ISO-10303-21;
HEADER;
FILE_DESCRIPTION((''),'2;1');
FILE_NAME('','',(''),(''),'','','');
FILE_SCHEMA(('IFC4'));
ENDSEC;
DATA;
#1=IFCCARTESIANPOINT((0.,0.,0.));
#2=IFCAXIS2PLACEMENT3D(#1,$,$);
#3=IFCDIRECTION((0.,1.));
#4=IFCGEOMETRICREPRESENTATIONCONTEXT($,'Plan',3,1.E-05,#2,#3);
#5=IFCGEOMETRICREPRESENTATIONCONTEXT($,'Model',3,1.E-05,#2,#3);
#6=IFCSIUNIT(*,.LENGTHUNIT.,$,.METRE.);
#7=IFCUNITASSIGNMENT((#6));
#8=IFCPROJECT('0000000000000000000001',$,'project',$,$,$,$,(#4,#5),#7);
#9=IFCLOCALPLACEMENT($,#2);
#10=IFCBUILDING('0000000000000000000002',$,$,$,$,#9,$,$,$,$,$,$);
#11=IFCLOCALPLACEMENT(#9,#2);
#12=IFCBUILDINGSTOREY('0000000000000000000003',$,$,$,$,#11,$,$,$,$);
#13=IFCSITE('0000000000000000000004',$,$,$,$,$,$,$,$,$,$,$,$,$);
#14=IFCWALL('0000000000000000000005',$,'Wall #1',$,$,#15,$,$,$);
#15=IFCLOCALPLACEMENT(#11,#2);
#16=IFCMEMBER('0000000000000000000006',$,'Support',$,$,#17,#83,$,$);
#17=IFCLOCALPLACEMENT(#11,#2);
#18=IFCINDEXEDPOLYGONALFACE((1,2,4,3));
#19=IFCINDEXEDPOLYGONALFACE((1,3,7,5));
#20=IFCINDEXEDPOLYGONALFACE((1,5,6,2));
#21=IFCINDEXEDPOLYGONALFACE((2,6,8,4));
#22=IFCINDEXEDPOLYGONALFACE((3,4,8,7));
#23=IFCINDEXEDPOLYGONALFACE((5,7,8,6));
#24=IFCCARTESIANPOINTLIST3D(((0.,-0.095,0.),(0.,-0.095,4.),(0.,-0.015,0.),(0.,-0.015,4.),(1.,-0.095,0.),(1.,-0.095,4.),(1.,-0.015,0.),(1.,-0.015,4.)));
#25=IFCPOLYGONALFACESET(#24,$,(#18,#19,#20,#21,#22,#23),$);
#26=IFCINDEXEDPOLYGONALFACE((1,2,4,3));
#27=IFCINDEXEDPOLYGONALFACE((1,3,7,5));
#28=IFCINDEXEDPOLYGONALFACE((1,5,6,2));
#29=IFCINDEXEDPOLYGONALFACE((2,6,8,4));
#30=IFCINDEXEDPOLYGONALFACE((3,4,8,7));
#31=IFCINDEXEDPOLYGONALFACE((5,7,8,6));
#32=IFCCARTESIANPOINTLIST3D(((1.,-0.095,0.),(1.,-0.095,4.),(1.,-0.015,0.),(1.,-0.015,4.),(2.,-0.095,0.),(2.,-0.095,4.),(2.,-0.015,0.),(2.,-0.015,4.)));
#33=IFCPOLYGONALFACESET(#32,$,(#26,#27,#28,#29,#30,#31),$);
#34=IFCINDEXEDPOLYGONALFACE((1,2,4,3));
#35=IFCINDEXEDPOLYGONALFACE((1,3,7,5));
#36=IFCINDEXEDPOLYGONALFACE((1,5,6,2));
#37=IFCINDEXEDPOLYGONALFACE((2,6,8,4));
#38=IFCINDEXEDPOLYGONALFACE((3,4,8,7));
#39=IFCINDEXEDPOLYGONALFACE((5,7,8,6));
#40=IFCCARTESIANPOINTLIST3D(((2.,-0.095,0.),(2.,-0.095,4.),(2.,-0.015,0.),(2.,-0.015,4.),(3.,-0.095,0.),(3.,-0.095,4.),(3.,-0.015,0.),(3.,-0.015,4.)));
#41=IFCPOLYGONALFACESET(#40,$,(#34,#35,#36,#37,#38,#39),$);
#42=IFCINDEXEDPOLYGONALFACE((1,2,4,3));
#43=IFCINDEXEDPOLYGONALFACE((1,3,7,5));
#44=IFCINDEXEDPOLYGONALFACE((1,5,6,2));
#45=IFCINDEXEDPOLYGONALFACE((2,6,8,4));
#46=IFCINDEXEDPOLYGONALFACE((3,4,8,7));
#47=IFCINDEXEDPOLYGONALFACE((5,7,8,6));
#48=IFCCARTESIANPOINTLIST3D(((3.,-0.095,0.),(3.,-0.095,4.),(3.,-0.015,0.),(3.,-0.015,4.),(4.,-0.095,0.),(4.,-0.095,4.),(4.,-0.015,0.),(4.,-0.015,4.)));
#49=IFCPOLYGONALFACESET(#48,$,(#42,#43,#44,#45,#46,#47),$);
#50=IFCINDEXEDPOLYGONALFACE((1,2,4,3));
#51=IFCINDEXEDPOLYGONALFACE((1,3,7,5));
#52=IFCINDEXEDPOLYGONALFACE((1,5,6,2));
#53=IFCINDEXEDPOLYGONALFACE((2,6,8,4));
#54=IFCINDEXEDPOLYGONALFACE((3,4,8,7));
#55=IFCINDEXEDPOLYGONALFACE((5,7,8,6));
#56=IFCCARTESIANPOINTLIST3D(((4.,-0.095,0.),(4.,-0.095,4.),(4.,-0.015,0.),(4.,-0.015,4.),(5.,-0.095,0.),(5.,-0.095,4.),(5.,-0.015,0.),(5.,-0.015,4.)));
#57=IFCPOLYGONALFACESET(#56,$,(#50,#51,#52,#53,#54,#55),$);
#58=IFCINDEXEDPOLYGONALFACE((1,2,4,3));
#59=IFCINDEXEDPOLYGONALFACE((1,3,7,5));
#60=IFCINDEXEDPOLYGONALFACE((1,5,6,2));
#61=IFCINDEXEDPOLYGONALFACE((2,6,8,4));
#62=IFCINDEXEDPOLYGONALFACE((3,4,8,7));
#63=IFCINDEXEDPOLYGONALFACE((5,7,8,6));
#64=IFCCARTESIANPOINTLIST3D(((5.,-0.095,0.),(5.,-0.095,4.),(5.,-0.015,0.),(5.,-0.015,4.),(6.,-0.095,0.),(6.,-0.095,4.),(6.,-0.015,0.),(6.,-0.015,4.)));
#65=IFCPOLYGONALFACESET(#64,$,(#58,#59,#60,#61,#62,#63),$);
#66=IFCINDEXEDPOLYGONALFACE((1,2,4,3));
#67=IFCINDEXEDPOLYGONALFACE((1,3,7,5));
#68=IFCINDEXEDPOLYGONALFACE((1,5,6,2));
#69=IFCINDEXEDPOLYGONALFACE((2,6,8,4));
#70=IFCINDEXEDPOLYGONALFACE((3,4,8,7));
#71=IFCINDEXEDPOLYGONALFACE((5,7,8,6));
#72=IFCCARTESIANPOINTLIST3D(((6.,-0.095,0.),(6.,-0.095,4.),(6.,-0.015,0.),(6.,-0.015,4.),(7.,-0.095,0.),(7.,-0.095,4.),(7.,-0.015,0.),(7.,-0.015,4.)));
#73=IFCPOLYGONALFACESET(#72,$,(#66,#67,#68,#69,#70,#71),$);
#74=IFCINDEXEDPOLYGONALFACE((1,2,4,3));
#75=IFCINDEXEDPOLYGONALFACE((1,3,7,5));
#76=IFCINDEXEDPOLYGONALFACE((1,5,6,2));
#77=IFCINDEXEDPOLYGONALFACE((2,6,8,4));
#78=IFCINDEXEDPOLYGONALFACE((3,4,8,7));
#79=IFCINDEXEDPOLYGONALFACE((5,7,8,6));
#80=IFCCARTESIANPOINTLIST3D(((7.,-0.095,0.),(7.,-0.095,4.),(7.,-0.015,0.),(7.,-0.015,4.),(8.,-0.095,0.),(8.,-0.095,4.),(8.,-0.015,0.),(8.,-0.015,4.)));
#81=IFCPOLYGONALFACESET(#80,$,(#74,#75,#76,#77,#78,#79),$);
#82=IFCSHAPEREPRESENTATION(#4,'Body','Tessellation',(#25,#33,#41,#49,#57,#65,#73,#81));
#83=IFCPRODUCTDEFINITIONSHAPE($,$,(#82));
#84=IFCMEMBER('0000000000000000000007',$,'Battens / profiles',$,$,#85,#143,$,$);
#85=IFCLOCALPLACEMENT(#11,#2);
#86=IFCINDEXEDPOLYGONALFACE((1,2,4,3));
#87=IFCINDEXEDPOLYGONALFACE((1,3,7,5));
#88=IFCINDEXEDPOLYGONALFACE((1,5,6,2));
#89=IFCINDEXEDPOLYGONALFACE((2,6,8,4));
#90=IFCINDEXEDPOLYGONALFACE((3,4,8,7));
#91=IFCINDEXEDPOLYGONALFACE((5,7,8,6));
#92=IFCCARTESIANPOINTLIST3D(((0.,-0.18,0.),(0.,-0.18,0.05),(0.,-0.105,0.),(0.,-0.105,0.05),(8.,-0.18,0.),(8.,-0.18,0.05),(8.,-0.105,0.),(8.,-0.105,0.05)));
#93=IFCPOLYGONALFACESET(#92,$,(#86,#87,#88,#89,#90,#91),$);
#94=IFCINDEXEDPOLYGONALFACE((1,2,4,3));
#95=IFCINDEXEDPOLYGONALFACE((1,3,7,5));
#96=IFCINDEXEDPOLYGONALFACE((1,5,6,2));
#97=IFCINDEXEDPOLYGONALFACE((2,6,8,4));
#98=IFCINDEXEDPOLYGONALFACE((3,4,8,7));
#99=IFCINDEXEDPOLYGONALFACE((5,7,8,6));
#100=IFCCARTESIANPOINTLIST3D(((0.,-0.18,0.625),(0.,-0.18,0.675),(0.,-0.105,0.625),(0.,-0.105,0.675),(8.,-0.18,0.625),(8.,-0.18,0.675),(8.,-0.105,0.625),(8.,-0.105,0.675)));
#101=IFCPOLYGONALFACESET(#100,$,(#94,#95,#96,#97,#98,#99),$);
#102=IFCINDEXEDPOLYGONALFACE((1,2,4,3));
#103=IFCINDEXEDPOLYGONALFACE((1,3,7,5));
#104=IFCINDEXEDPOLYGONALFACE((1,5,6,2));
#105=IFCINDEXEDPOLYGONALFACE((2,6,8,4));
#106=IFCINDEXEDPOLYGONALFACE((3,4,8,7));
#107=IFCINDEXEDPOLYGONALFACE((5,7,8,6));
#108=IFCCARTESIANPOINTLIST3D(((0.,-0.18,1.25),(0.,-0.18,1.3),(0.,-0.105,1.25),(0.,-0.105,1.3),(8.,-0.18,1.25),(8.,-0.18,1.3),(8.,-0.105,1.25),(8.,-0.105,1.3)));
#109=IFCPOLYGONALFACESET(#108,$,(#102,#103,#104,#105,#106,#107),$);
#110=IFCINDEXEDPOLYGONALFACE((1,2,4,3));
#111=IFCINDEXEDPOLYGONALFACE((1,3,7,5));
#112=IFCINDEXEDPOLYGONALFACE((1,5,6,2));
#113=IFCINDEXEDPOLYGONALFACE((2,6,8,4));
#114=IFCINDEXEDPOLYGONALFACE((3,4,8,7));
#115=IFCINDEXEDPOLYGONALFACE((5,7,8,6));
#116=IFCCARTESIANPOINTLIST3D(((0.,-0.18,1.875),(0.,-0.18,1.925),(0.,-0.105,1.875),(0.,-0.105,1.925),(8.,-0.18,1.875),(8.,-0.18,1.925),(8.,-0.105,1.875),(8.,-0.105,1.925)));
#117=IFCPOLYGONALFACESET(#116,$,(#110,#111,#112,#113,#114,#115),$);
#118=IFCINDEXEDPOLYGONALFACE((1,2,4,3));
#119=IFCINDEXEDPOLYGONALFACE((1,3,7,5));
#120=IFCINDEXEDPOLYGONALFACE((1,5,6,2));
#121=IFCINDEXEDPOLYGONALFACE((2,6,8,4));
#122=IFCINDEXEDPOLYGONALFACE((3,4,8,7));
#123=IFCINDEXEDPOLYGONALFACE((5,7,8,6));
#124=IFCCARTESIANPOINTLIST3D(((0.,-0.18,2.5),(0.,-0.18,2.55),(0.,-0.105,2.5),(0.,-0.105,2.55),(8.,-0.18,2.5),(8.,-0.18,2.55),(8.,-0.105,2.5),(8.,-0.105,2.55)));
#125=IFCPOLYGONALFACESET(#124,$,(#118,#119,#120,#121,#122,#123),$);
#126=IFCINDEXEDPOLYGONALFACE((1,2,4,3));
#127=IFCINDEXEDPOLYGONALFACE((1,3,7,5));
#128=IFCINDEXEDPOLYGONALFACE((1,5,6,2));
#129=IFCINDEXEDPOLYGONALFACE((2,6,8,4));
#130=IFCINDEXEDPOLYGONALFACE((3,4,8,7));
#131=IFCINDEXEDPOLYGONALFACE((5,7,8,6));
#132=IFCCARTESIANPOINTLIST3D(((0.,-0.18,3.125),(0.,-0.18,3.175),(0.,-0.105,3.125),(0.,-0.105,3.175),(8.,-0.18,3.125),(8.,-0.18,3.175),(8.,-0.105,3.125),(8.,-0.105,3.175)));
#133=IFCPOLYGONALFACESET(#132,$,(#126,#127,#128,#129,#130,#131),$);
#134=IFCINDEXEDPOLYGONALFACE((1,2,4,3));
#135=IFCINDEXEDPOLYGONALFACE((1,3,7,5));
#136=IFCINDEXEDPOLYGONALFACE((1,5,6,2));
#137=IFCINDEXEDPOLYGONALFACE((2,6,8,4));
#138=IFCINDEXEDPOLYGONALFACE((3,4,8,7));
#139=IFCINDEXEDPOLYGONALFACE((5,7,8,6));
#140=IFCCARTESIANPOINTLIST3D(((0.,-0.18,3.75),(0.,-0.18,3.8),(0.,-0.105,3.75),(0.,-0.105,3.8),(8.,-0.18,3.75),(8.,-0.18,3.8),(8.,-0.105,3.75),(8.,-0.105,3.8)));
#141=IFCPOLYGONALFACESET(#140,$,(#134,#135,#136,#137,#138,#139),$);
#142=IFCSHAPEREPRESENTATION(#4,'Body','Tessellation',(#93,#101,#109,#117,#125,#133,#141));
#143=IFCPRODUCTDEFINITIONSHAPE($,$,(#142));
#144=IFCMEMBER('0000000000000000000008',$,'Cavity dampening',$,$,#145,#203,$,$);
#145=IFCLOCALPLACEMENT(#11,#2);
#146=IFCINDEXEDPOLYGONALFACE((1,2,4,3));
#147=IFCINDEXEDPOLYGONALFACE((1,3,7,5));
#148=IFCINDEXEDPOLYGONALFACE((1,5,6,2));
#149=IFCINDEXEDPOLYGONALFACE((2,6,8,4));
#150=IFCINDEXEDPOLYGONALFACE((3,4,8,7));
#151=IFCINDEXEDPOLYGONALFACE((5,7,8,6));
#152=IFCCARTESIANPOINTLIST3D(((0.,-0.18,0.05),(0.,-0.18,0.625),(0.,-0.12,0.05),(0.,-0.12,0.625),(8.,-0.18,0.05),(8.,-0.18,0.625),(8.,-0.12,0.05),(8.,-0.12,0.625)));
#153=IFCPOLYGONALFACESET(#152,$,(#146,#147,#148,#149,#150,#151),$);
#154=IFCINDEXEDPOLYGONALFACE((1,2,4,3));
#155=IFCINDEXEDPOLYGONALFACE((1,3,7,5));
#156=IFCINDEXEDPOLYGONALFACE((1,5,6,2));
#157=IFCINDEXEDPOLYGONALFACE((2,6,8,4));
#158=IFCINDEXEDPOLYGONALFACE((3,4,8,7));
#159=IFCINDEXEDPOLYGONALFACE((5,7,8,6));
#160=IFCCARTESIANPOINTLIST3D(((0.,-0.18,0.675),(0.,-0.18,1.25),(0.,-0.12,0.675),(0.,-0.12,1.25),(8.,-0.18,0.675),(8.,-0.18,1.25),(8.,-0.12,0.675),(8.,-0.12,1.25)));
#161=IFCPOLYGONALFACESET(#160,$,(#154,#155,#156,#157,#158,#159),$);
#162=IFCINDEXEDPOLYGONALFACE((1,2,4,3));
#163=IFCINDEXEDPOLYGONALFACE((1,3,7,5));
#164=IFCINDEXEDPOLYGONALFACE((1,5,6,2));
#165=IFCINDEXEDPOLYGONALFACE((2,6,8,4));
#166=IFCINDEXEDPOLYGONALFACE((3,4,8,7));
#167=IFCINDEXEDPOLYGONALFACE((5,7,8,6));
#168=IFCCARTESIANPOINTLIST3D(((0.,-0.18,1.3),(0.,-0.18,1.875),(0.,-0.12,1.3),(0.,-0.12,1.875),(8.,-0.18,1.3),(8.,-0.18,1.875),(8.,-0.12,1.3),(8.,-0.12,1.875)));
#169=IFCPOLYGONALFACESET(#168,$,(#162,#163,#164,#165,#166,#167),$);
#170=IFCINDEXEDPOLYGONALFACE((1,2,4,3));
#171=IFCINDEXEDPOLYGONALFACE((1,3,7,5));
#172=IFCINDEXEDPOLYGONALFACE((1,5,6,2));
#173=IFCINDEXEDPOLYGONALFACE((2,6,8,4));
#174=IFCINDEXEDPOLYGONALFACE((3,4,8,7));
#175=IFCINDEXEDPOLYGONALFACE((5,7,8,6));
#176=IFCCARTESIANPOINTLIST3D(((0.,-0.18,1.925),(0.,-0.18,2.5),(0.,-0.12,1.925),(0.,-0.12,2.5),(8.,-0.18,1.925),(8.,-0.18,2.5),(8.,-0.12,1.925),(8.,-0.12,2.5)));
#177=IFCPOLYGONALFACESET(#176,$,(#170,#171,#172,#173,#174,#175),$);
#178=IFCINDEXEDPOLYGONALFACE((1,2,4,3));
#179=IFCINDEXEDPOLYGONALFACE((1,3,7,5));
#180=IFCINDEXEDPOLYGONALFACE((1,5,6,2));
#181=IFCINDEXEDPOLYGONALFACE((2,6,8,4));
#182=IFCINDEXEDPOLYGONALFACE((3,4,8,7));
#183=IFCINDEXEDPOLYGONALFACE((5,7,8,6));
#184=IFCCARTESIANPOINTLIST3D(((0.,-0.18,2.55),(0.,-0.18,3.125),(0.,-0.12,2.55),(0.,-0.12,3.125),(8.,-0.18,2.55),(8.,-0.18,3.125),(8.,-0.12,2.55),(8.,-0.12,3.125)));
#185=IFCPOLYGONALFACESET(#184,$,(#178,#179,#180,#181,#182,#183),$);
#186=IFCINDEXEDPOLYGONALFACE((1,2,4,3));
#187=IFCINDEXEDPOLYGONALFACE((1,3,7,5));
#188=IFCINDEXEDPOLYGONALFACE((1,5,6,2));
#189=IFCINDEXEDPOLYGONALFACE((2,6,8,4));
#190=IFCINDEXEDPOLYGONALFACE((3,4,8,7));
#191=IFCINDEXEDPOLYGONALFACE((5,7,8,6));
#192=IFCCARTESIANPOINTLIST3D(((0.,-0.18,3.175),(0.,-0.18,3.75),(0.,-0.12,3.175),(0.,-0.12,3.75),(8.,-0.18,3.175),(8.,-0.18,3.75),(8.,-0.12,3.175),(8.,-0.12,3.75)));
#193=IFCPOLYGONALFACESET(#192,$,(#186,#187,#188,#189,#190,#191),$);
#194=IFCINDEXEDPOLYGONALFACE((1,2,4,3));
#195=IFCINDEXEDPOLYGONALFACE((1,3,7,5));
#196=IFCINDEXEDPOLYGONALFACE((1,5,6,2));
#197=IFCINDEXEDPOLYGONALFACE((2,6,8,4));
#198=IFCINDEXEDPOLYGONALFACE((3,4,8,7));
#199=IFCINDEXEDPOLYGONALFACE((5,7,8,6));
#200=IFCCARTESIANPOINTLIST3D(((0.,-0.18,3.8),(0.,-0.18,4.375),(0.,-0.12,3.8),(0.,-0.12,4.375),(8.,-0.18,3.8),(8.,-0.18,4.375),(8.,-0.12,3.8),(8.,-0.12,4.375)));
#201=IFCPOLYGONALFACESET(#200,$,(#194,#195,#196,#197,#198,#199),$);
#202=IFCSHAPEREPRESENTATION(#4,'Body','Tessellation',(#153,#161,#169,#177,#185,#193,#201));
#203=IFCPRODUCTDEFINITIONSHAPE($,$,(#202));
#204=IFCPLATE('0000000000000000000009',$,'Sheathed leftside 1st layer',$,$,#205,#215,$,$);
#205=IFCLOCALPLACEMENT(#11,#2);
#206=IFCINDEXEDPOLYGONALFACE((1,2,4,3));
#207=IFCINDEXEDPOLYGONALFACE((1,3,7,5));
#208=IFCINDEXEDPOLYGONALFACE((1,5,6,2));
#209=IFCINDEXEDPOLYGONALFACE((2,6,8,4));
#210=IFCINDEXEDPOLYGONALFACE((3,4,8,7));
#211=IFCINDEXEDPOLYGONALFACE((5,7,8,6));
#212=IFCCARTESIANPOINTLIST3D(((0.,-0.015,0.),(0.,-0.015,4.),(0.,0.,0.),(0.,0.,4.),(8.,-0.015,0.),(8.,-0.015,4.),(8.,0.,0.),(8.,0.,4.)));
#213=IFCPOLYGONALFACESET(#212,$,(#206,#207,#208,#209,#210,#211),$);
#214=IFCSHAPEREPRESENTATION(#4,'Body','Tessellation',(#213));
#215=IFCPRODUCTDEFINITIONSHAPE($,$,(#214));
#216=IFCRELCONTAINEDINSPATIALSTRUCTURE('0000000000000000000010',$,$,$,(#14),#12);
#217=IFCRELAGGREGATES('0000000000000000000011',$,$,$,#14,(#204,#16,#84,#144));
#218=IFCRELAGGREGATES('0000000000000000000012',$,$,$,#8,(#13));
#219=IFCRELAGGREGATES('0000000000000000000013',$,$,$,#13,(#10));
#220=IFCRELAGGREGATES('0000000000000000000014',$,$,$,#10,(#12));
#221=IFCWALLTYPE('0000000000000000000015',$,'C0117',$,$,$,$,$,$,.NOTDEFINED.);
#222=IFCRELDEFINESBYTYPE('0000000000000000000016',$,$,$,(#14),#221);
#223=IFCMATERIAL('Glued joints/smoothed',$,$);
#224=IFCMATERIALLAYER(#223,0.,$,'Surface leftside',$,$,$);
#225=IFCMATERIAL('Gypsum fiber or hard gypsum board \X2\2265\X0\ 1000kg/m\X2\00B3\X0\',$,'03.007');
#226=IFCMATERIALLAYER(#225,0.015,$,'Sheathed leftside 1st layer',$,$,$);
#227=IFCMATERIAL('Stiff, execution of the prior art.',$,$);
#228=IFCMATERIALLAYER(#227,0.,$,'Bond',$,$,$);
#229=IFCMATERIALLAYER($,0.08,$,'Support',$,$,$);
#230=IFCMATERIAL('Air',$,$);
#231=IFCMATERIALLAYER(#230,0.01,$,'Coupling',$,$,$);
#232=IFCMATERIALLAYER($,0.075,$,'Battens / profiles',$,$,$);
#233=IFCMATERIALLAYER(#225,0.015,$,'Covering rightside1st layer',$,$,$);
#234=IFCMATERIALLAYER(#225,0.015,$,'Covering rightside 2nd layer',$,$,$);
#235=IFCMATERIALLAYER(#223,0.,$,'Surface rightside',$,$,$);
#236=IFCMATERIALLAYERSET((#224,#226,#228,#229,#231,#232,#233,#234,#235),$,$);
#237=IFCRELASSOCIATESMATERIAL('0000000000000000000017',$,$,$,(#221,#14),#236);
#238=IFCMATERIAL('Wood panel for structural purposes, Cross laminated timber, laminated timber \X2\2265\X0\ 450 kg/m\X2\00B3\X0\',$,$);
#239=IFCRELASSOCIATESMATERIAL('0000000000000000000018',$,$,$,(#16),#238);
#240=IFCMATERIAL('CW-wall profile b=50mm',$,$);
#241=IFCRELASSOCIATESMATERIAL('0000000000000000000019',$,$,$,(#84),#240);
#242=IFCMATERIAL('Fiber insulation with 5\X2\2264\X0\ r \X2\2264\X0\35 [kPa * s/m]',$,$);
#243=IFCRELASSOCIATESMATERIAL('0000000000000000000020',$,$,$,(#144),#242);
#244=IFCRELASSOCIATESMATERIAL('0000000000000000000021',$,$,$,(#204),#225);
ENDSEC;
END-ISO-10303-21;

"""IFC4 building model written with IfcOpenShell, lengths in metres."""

from ifc_helpers import new_model, si_unit, direction, frame, frame_2d, origin, origin_with_axes, place, context, project, spatial, rectangle, extrude, material, layer, layer_set, type_object, element, aggregate, save


model = new_model("IFC4")

# Units and contexts
plan_context = context("Plan", 3, precision=1e-05, world=origin(), true_north=direction((0.0, 1.0)))
model_context = context("Model", 3, precision=1e-05, world=origin(), true_north=direction((0.0, 1.0)))
ifc_project = project(units=[si_unit("LENGTHUNIT", "METRE")], contexts=[plan_context, model_context])

# Site, building, storey
site = spatial("IfcSite", under=ifc_project)
building_placement = place(None, origin())
building = spatial("IfcBuilding", under=site, at=building_placement)
storey_placement = place(building_placement, origin())
storey = spatial("IfcBuildingStorey", under=building, at=storey_placement)

# Wall, members, plate
ifc_material_1 = material(Name="Glued joints/smoothed")
ifc_layer_1 = layer(ifc_material_1, 0.0, Name="Surface leftside")
ifc_material_2 = material(Name="Gypsum fiber or hard gypsum board ≥ 1000kg/m³", Category="03.007")
ifc_layer_2 = layer(ifc_material_2, 0.015, Name="Sheathed leftside 1st layer")
ifc_material_3 = material(Name="Stiff, execution of the prior art.")
ifc_layer_3 = layer(ifc_material_3, 0.0, Name="Bond")
ifc_layer_4 = layer(None, 0.08, Name="Support")
ifc_material_4 = material(Name="Air")
ifc_layer_5 = layer(ifc_material_4, 0.01, Name="Coupling")
ifc_layer_6 = layer(None, 0.075, Name="Battens / profiles")
ifc_layer_7 = layer(ifc_material_2, 0.015, Name="Covering rightside1st layer")
ifc_layer_8 = layer(ifc_material_2, 0.015, Name="Covering rightside 2nd layer")
ifc_layer_9 = layer(ifc_material_1, 0.0, Name="Surface rightside")
ifc_layer_set = layer_set([ifc_layer_1, ifc_layer_2, ifc_layer_3, ifc_layer_4, ifc_layer_5, ifc_layer_6, ifc_layer_7, ifc_layer_8, ifc_layer_9])
wall_type = type_object("IfcWallType", Name="C0117", PredefinedType="NOTDEFINED", material=ifc_layer_set)
wall_placement = place(None, frame((0.0, 0.0, 0.0), z_axis=(0.0, -1.0, 0.0), x_axis=(1.0, 0.0, 0.0)))
wall = element("IfcWall", 1, at=wall_placement, inside=storey, type_object=wall_type, material=ifc_layer_set, Name="Wall #1")
ifc_material_5 = material(Name="Wood panel for structural purposes, Cross laminated timber, laminated timber ≥ 450 kg/m³")
member_1_placement = place(wall_placement, origin())
member_1 = element("IfcMember", 2, at=member_1_placement, material=ifc_material_5, Name="Support", context=plan_context, shape_type="SweptSolid", body=[
    extrude(rectangle(XDim=1.0, YDim=0.08, at=frame_2d((0.5, 0.04), x_axis=(1.0, 0.0))), frame((0.0, 4.0, 0.015), z_axis=(0.0, -1.0, 0.0), x_axis=(1.0, 0.0, 0.0)), (0.0, 0.0, 1.0), 4.0),
    extrude(rectangle(XDim=1.0, YDim=0.08, at=frame_2d((0.5, 0.04), x_axis=(1.0, 0.0))), frame((1.0, 4.0, 0.015), z_axis=(0.0, -1.0, 0.0), x_axis=(1.0, 0.0, 0.0)), (0.0, 0.0, 1.0), 4.0),
    extrude(rectangle(XDim=1.0, YDim=0.08, at=frame_2d((0.5, 0.04), x_axis=(1.0, 0.0))), frame((2.0, 4.0, 0.015), z_axis=(0.0, -1.0, 0.0), x_axis=(1.0, 0.0, 0.0)), (0.0, 0.0, 1.0), 4.0),
    extrude(rectangle(XDim=1.0, YDim=0.08, at=frame_2d((0.5, 0.04), x_axis=(1.0, 0.0))), frame((3.0, 4.0, 0.015), z_axis=(0.0, -1.0, 0.0), x_axis=(1.0, 0.0, 0.0)), (0.0, 0.0, 1.0), 4.0),
    extrude(rectangle(XDim=1.0, YDim=0.08, at=frame_2d((0.5, 0.04), x_axis=(1.0, 0.0))), frame((4.0, 4.0, 0.015), z_axis=(0.0, -1.0, 0.0), x_axis=(1.0, 0.0, 0.0)), (0.0, 0.0, 1.0), 4.0),
    extrude(rectangle(XDim=1.0, YDim=0.08, at=frame_2d((0.5, 0.04), x_axis=(1.0, 0.0))), frame((5.0, 4.0, 0.015), z_axis=(0.0, -1.0, 0.0), x_axis=(1.0, 0.0, 0.0)), (0.0, 0.0, 1.0), 4.0),
    extrude(rectangle(XDim=1.0, YDim=0.08, at=frame_2d((0.5, 0.04), x_axis=(1.0, 0.0))), frame((6.0, 4.0, 0.015), z_axis=(0.0, -1.0, 0.0), x_axis=(1.0, 0.0, 0.0)), (0.0, 0.0, 1.0), 4.0),
    extrude(rectangle(XDim=1.0, YDim=0.08, at=frame_2d((0.5, 0.04), x_axis=(1.0, 0.0))), frame((7.0, 4.0, 0.015), z_axis=(0.0, -1.0, 0.0), x_axis=(1.0, 0.0, 0.0)), (0.0, 0.0, 1.0), 4.0),
])
ifc_material_6 = material(Name="CW-wall profile b=50mm")
member_2_placement = place(wall_placement, origin())
member_2 = element("IfcMember", 3, at=member_2_placement, material=ifc_material_6, Name="Battens / profiles", context=plan_context, shape_type="SweptSolid", body=[
    extrude(rectangle(XDim=0.05, YDim=0.075, at=frame_2d((0.025, 0.0375), x_axis=(1.0, 0.0))), frame((0.0, 0.0, 0.105), z_axis=(1.0, 0.0, 0.0), x_axis=(0.0, 1.0, 0.0)), (0.0, 0.0, 1.0), 8.0),
    extrude(rectangle(XDim=0.05, YDim=0.075, at=frame_2d((0.025, 0.0375), x_axis=(1.0, 0.0))), frame((0.0, 0.625, 0.105), z_axis=(1.0, 0.0, 0.0), x_axis=(0.0, 1.0, 0.0)), (0.0, 0.0, 1.0), 8.0),
    extrude(rectangle(XDim=0.05, YDim=0.075, at=frame_2d((0.025, 0.0375), x_axis=(1.0, 0.0))), frame((0.0, 1.25, 0.105), z_axis=(1.0, 0.0, 0.0), x_axis=(0.0, 1.0, 0.0)), (0.0, 0.0, 1.0), 8.0),
    extrude(rectangle(XDim=0.05, YDim=0.075, at=frame_2d((0.025, 0.0375), x_axis=(1.0, 0.0))), frame((0.0, 1.875, 0.105), z_axis=(1.0, 0.0, 0.0), x_axis=(0.0, 1.0, 0.0)), (0.0, 0.0, 1.0), 8.0),
    extrude(rectangle(XDim=0.05, YDim=0.075, at=frame_2d((0.025, 0.0375), x_axis=(1.0, 0.0))), frame((0.0, 2.5, 0.105), z_axis=(1.0, 0.0, 0.0), x_axis=(0.0, 1.0, 0.0)), (0.0, 0.0, 1.0), 8.0),
    extrude(rectangle(XDim=0.05, YDim=0.075, at=frame_2d((0.025, 0.0375), x_axis=(1.0, 0.0))), frame((0.0, 3.125, 0.105), z_axis=(1.0, 0.0, 0.0), x_axis=(0.0, 1.0, 0.0)), (0.0, 0.0, 1.0), 8.0),
    extrude(rectangle(XDim=0.05, YDim=0.075, at=frame_2d((0.025, 0.0375), x_axis=(1.0, 0.0))), frame((0.0, 3.75, 0.105), z_axis=(1.0, 0.0, 0.0), x_axis=(0.0, 1.0, 0.0)), (0.0, 0.0, 1.0), 8.0),
])
ifc_material_7 = material(Name="Fiber insulation with 5≤ r ≤35 [kPa * s/m]")
member_3_placement = place(wall_placement, origin())
member_3 = element("IfcMember", 4, at=member_3_placement, material=ifc_material_7, Name="Cavity dampening", context=plan_context, shape_type="SweptSolid", body=[
    extrude(rectangle(XDim=0.575, YDim=0.06, at=frame_2d((0.2875, 0.03), x_axis=(1.0, 0.0))), frame((0.0, 0.05, 0.12), z_axis=(1.0, 0.0, 0.0), x_axis=(0.0, 1.0, 0.0)), (0.0, 0.0, 1.0), 8.0),
    extrude(rectangle(XDim=0.575, YDim=0.06, at=frame_2d((0.2875, 0.03), x_axis=(1.0, 0.0))), frame((0.0, 0.675, 0.12), z_axis=(1.0, 0.0, 0.0), x_axis=(0.0, 1.0, 0.0)), (0.0, 0.0, 1.0), 8.0),
    extrude(rectangle(XDim=0.575, YDim=0.06, at=frame_2d((0.2875, 0.03), x_axis=(1.0, 0.0))), frame((0.0, 1.3, 0.12), z_axis=(1.0, 0.0, 0.0), x_axis=(0.0, 1.0, 0.0)), (0.0, 0.0, 1.0), 8.0),
    extrude(rectangle(XDim=0.575, YDim=0.06, at=frame_2d((0.2875, 0.03), x_axis=(1.0, 0.0))), frame((0.0, 1.925, 0.12), z_axis=(1.0, 0.0, 0.0), x_axis=(0.0, 1.0, 0.0)), (0.0, 0.0, 1.0), 8.0),
    extrude(rectangle(XDim=0.575, YDim=0.06, at=frame_2d((0.2875, 0.03), x_axis=(1.0, 0.0))), frame((0.0, 2.55, 0.12), z_axis=(1.0, 0.0, 0.0), x_axis=(0.0, 1.0, 0.0)), (0.0, 0.0, 1.0), 8.0),
    extrude(rectangle(XDim=0.575, YDim=0.06, at=frame_2d((0.2875, 0.03), x_axis=(1.0, 0.0))), frame((0.0, 3.175, 0.12), z_axis=(1.0, 0.0, 0.0), x_axis=(0.0, 1.0, 0.0)), (0.0, 0.0, 1.0), 8.0),
    extrude(rectangle(XDim=0.575, YDim=0.06, at=frame_2d((0.2875, 0.03), x_axis=(1.0, 0.0))), frame((0.0, 3.8, 0.12), z_axis=(1.0, 0.0, 0.0), x_axis=(0.0, 1.0, 0.0)), (0.0, 0.0, 1.0), 8.0),
])
plate_1_placement = place(wall_placement, origin())
plate_1 = element("IfcPlate", 5, at=plate_1_placement, material=ifc_material_2, Name="Sheathed leftside 1st layer", context=plan_context, shape_type="SweptSolid", body=[
    extrude(rectangle(XDim=8.0, YDim=4.0, at=frame_2d((4.0, 2.0), x_axis=(1.0, 0.0))), origin_with_axes(), (0.0, 0.0, 1.0), 0.015),
])
aggregate(wall, [plate_1, member_1, member_2, member_3])

save(model, "model.ifc")
